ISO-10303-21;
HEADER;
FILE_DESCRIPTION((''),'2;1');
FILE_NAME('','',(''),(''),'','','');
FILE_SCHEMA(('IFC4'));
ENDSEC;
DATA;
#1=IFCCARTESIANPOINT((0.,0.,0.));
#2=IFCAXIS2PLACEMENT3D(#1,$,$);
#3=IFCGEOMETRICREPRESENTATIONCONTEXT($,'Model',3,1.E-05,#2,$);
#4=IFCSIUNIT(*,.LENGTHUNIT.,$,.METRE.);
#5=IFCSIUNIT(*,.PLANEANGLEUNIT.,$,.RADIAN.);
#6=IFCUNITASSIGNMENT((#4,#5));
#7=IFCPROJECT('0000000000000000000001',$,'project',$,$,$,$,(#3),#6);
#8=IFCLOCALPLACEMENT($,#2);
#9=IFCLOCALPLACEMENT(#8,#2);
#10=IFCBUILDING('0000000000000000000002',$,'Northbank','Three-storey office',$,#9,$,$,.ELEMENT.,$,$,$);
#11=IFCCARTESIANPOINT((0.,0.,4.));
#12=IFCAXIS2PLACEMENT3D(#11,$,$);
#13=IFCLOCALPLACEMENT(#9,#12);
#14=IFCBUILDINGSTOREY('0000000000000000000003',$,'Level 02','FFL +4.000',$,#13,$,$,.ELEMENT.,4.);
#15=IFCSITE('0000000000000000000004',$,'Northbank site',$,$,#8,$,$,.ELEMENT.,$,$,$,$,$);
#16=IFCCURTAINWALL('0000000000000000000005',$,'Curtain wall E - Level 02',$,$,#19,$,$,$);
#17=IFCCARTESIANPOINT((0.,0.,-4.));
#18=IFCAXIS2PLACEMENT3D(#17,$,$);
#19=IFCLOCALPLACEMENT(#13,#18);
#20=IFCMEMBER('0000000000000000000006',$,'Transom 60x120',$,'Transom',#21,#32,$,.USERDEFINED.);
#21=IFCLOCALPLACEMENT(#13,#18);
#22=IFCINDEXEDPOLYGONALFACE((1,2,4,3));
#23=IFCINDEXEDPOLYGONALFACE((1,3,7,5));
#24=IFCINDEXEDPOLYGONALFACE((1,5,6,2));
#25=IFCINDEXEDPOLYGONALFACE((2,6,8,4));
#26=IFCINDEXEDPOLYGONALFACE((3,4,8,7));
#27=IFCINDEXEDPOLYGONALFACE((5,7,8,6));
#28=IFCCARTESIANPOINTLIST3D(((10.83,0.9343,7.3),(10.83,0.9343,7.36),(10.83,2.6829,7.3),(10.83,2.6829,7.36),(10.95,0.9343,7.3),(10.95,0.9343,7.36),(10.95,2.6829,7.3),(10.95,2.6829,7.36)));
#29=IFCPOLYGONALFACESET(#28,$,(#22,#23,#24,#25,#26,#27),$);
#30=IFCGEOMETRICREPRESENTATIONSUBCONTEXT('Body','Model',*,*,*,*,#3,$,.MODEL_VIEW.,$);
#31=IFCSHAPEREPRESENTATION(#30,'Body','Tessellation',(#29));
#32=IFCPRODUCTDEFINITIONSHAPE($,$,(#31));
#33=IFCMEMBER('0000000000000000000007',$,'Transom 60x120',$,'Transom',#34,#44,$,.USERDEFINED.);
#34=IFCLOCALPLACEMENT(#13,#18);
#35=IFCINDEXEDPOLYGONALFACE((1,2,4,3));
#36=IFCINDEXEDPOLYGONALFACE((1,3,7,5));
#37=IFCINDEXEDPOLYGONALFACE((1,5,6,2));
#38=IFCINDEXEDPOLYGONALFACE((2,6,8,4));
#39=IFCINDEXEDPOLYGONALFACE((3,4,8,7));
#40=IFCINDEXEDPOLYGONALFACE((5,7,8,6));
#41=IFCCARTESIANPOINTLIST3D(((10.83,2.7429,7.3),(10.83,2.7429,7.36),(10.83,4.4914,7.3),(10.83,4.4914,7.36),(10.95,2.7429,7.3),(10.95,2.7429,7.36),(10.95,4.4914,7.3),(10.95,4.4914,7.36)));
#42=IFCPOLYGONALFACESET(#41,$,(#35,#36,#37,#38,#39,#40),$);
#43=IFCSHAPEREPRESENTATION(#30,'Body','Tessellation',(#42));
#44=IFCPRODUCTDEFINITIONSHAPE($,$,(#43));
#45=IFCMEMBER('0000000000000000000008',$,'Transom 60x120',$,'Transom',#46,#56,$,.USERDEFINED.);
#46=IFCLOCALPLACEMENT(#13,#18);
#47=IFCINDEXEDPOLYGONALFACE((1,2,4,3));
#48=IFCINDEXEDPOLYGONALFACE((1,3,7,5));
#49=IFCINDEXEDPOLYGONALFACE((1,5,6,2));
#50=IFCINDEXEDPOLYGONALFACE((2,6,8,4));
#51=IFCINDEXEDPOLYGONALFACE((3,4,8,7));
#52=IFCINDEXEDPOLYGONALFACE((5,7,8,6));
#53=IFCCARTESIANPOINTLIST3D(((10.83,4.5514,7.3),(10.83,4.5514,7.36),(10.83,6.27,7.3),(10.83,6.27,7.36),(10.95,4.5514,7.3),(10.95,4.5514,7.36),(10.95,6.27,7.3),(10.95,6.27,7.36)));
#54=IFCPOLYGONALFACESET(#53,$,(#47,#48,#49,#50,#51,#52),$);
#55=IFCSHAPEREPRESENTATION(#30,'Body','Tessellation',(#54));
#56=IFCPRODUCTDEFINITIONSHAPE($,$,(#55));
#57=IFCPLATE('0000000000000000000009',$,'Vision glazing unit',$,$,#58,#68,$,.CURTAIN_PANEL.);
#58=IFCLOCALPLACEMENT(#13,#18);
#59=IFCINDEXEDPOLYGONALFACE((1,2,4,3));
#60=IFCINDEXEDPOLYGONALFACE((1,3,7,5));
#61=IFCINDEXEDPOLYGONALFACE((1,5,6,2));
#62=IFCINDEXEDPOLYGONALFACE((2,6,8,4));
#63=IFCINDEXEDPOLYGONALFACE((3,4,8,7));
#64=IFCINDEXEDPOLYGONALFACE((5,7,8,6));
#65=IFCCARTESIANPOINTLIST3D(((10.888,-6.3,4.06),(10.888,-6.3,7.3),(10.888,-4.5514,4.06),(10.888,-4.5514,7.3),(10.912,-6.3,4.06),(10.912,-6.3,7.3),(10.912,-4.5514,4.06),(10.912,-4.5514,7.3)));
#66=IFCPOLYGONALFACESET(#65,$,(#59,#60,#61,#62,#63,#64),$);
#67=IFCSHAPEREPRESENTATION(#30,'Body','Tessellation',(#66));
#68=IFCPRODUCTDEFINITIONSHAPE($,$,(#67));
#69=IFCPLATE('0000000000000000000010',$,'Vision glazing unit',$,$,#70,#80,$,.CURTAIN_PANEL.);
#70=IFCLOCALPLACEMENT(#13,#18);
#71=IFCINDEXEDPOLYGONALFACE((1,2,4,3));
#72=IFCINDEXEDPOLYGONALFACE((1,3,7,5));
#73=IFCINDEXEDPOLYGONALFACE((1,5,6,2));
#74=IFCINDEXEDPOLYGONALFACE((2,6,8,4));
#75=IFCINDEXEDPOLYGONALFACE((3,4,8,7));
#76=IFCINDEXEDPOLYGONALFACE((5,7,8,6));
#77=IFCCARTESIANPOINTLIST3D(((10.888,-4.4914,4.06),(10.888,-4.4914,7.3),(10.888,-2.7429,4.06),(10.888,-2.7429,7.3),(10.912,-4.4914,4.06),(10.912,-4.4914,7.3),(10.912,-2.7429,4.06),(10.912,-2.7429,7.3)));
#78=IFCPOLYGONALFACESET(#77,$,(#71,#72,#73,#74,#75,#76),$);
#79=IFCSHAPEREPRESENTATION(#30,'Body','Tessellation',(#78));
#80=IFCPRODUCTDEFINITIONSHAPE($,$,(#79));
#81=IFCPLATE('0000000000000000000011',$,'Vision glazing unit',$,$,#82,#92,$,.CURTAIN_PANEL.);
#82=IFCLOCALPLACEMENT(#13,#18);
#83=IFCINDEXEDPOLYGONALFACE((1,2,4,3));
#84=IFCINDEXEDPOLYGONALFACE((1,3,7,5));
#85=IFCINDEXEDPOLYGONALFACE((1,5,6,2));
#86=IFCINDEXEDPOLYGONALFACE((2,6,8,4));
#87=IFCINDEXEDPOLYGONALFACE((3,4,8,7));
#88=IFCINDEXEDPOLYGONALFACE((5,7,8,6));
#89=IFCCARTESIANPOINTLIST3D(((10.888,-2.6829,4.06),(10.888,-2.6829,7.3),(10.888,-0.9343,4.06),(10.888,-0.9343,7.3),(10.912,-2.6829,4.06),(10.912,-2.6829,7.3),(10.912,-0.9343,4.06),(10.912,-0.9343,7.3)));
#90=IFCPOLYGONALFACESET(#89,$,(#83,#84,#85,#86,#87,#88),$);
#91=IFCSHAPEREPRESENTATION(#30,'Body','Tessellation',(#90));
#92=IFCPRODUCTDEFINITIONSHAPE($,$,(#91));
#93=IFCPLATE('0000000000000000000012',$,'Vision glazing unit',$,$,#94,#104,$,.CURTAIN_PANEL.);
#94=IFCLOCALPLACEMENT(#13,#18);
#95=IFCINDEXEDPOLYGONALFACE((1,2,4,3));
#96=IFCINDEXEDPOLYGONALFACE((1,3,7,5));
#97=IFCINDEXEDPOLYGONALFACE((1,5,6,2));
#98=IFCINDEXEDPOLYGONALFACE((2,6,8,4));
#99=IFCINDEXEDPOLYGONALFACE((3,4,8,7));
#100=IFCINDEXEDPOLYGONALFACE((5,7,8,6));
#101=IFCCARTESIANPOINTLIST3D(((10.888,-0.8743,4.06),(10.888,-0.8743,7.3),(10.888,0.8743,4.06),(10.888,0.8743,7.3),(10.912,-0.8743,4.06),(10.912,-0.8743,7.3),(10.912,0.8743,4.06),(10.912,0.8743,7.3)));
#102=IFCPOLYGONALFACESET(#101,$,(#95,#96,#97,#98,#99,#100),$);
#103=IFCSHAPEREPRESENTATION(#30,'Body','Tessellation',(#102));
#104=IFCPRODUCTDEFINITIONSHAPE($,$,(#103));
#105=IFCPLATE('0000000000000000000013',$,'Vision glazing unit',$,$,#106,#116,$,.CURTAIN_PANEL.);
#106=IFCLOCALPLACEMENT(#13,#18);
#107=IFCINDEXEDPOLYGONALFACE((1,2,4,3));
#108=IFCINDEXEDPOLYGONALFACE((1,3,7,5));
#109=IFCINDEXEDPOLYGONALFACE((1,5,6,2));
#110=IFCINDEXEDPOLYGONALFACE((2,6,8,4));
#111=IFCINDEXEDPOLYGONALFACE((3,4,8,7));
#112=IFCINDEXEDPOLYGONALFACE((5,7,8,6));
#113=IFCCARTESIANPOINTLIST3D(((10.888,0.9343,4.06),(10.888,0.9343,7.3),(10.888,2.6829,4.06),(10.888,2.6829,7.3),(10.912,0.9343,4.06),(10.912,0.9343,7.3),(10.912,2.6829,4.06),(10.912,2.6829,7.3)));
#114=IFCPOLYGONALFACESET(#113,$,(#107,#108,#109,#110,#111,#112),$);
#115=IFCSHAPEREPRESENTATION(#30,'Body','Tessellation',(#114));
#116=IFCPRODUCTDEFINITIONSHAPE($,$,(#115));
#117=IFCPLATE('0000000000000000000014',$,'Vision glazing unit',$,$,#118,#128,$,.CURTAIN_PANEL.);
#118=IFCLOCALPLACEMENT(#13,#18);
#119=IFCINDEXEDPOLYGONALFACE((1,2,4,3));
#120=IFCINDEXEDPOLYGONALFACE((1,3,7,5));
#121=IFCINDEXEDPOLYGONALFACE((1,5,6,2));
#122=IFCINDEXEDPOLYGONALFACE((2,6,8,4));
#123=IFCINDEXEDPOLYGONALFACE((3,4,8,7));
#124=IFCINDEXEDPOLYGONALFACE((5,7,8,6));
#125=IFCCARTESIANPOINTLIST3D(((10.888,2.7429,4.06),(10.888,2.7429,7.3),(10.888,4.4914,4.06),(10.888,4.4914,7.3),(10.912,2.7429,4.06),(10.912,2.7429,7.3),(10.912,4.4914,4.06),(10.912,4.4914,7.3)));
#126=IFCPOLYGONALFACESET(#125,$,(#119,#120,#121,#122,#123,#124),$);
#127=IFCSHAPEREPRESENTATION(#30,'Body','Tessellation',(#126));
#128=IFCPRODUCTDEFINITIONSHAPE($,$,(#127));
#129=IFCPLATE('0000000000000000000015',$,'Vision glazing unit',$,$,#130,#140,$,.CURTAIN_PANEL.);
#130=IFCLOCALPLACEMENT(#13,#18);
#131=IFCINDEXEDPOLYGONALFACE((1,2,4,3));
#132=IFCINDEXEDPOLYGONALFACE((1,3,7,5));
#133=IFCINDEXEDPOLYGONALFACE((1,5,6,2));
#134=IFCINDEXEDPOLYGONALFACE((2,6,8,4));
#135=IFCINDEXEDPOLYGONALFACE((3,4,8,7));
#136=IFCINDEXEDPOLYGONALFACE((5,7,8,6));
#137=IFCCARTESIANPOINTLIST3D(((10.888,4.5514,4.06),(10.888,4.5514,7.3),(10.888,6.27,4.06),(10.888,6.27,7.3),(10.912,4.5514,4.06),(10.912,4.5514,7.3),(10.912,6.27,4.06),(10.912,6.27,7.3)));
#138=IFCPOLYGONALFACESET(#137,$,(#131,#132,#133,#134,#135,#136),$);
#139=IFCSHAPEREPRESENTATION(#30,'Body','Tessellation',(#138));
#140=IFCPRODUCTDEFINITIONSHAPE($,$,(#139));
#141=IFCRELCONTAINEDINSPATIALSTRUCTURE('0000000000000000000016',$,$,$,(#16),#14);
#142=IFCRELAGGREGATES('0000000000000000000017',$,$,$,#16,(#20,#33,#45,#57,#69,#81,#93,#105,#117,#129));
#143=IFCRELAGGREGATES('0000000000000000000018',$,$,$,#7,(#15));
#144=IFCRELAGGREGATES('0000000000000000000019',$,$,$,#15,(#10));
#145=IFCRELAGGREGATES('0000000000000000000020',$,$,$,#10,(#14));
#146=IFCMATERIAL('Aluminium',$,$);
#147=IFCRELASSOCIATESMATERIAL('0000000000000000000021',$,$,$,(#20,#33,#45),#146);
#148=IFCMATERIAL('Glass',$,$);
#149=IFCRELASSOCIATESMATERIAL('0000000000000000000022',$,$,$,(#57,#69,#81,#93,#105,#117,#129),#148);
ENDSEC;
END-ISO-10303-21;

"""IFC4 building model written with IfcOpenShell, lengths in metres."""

from ifc_helpers import new_model, si_unit, frame, origin, place, context, subcontext, project, spatial, rectangle, extrude, material, element, aggregate, save


model = new_model("IFC4")

# Units and contexts
model_context = context("Model", 3, precision=1e-05, world=origin())
body_context = subcontext(model_context, "Body", "Model", "MODEL_VIEW")
ifc_project = project(units=[si_unit("LENGTHUNIT", "METRE"), si_unit("PLANEANGLEUNIT", "RADIAN")], contexts=[model_context])

# Site, building, storey
site_placement = place(None, origin())
site = spatial("IfcSite", under=ifc_project, at=site_placement, Name="Northbank site", CompositionType="ELEMENT")
building_placement = place(site_placement, origin())
building = spatial("IfcBuilding", under=site, at=building_placement, Name="Northbank", Description="Three-storey office", CompositionType="ELEMENT")
storey_placement = place(building_placement, frame((0.0, 0.0, 4.0)))
storey = spatial("IfcBuildingStorey", under=building, at=storey_placement, Name="Level 02", Description="FFL +4.000", CompositionType="ELEMENT", Elevation=4.0)

# Curtain wall, members, plates
curtain_wall_placement = place(storey_placement, frame((0.0, 0.0, -4.0)))
curtain_wall = element("IfcCurtainWall", 1, at=curtain_wall_placement, inside=storey, Name="Curtain wall E - Level 02")
ifc_material_1 = material(Name="Aluminium")
member_1_placement = place(storey_placement, frame((0.0, 0.0, -4.0)))
member_1 = element("IfcMember", 2, at=member_1_placement, material=ifc_material_1, Name="Transom 60x120", ObjectType="Transom", PredefinedType="USERDEFINED", context=body_context, shape_type="SweptSolid", body=[
    extrude(rectangle(XDim=0.12, YDim=1.7486), frame((10.89, 1.8086, 7.3)), (0.0, 0.0, 1.0), 0.06),
])
member_2_placement = place(storey_placement, frame((0.0, 0.0, -4.0)))
member_2 = element("IfcMember", 3, at=member_2_placement, material=ifc_material_1, Name="Transom 60x120", ObjectType="Transom", PredefinedType="USERDEFINED", context=body_context, shape_type="SweptSolid", body=[
    extrude(rectangle(XDim=0.12, YDim=1.7486), frame((10.89, 3.6171, 7.3)), (0.0, 0.0, 1.0), 0.06),
])
member_3_placement = place(storey_placement, frame((0.0, 0.0, -4.0)))
member_3 = element("IfcMember", 4, at=member_3_placement, material=ifc_material_1, Name="Transom 60x120", ObjectType="Transom", PredefinedType="USERDEFINED", context=body_context, shape_type="SweptSolid", body=[
    extrude(rectangle(XDim=0.12, YDim=1.7186), frame((10.89, 5.4107, 7.3)), (0.0, 0.0, 1.0), 0.06),
])
ifc_material_2 = material(Name="Glass")
plate_1_placement = place(storey_placement, frame((0.0, 0.0, -4.0)))
plate_1 = element("IfcPlate", 5, at=plate_1_placement, material=ifc_material_2, Name="Vision glazing unit", PredefinedType="CURTAIN_PANEL", context=body_context, shape_type="SweptSolid", body=[
    extrude(rectangle(XDim=0.024, YDim=1.7486), frame((10.9, -5.4257, 4.06)), (0.0, 0.0, 1.0), 3.24),
])
plate_2_placement = place(storey_placement, frame((0.0, 0.0, -4.0)))
plate_2 = element("IfcPlate", 6, at=plate_2_placement, material=ifc_material_2, Name="Vision glazing unit", PredefinedType="CURTAIN_PANEL", context=body_context, shape_type="SweptSolid", body=[
    extrude(rectangle(XDim=0.024, YDim=1.7486), frame((10.9, -3.6171, 4.06)), (0.0, 0.0, 1.0), 3.24),
])
plate_3_placement = place(storey_placement, frame((0.0, 0.0, -4.0)))
plate_3 = element("IfcPlate", 7, at=plate_3_placement, material=ifc_material_2, Name="Vision glazing unit", PredefinedType="CURTAIN_PANEL", context=body_context, shape_type="SweptSolid", body=[
    extrude(rectangle(XDim=0.024, YDim=1.7486), frame((10.9, -1.8086, 4.06)), (0.0, 0.0, 1.0), 3.24),
])
plate_4_placement = place(storey_placement, frame((0.0, 0.0, -4.0)))
plate_4 = element("IfcPlate", 8, at=plate_4_placement, material=ifc_material_2, Name="Vision glazing unit", PredefinedType="CURTAIN_PANEL", context=body_context, shape_type="SweptSolid", body=[
    extrude(rectangle(XDim=0.024, YDim=1.7486), frame((10.9, 0.0, 4.06)), (0.0, 0.0, 1.0), 3.24),
])
plate_5_placement = place(storey_placement, frame((0.0, 0.0, -4.0)))
plate_5 = element("IfcPlate", 9, at=plate_5_placement, material=ifc_material_2, Name="Vision glazing unit", PredefinedType="CURTAIN_PANEL", context=body_context, shape_type="SweptSolid", body=[
    extrude(rectangle(XDim=0.024, YDim=1.7486), frame((10.9, 1.8086, 4.06)), (0.0, 0.0, 1.0), 3.24),
])
plate_6_placement = place(storey_placement, frame((0.0, 0.0, -4.0)))
plate_6 = element("IfcPlate", 10, at=plate_6_placement, material=ifc_material_2, Name="Vision glazing unit", PredefinedType="CURTAIN_PANEL", context=body_context, shape_type="SweptSolid", body=[
    extrude(rectangle(XDim=0.024, YDim=1.7486), frame((10.9, 3.6171, 4.06)), (0.0, 0.0, 1.0), 3.24),
])
plate_7_placement = place(storey_placement, frame((0.0, 0.0, -4.0)))
plate_7 = element("IfcPlate", 11, at=plate_7_placement, material=ifc_material_2, Name="Vision glazing unit", PredefinedType="CURTAIN_PANEL", context=body_context, shape_type="SweptSolid", body=[
    extrude(rectangle(XDim=0.024, YDim=1.7186), frame((10.9, 5.4107, 4.06)), (0.0, 0.0, 1.0), 3.24),
])
aggregate(curtain_wall, [member_1, member_2, member_3, plate_1, plate_2, plate_3, plate_4, plate_5, plate_6, plate_7])

save(model, "model.ifc")
